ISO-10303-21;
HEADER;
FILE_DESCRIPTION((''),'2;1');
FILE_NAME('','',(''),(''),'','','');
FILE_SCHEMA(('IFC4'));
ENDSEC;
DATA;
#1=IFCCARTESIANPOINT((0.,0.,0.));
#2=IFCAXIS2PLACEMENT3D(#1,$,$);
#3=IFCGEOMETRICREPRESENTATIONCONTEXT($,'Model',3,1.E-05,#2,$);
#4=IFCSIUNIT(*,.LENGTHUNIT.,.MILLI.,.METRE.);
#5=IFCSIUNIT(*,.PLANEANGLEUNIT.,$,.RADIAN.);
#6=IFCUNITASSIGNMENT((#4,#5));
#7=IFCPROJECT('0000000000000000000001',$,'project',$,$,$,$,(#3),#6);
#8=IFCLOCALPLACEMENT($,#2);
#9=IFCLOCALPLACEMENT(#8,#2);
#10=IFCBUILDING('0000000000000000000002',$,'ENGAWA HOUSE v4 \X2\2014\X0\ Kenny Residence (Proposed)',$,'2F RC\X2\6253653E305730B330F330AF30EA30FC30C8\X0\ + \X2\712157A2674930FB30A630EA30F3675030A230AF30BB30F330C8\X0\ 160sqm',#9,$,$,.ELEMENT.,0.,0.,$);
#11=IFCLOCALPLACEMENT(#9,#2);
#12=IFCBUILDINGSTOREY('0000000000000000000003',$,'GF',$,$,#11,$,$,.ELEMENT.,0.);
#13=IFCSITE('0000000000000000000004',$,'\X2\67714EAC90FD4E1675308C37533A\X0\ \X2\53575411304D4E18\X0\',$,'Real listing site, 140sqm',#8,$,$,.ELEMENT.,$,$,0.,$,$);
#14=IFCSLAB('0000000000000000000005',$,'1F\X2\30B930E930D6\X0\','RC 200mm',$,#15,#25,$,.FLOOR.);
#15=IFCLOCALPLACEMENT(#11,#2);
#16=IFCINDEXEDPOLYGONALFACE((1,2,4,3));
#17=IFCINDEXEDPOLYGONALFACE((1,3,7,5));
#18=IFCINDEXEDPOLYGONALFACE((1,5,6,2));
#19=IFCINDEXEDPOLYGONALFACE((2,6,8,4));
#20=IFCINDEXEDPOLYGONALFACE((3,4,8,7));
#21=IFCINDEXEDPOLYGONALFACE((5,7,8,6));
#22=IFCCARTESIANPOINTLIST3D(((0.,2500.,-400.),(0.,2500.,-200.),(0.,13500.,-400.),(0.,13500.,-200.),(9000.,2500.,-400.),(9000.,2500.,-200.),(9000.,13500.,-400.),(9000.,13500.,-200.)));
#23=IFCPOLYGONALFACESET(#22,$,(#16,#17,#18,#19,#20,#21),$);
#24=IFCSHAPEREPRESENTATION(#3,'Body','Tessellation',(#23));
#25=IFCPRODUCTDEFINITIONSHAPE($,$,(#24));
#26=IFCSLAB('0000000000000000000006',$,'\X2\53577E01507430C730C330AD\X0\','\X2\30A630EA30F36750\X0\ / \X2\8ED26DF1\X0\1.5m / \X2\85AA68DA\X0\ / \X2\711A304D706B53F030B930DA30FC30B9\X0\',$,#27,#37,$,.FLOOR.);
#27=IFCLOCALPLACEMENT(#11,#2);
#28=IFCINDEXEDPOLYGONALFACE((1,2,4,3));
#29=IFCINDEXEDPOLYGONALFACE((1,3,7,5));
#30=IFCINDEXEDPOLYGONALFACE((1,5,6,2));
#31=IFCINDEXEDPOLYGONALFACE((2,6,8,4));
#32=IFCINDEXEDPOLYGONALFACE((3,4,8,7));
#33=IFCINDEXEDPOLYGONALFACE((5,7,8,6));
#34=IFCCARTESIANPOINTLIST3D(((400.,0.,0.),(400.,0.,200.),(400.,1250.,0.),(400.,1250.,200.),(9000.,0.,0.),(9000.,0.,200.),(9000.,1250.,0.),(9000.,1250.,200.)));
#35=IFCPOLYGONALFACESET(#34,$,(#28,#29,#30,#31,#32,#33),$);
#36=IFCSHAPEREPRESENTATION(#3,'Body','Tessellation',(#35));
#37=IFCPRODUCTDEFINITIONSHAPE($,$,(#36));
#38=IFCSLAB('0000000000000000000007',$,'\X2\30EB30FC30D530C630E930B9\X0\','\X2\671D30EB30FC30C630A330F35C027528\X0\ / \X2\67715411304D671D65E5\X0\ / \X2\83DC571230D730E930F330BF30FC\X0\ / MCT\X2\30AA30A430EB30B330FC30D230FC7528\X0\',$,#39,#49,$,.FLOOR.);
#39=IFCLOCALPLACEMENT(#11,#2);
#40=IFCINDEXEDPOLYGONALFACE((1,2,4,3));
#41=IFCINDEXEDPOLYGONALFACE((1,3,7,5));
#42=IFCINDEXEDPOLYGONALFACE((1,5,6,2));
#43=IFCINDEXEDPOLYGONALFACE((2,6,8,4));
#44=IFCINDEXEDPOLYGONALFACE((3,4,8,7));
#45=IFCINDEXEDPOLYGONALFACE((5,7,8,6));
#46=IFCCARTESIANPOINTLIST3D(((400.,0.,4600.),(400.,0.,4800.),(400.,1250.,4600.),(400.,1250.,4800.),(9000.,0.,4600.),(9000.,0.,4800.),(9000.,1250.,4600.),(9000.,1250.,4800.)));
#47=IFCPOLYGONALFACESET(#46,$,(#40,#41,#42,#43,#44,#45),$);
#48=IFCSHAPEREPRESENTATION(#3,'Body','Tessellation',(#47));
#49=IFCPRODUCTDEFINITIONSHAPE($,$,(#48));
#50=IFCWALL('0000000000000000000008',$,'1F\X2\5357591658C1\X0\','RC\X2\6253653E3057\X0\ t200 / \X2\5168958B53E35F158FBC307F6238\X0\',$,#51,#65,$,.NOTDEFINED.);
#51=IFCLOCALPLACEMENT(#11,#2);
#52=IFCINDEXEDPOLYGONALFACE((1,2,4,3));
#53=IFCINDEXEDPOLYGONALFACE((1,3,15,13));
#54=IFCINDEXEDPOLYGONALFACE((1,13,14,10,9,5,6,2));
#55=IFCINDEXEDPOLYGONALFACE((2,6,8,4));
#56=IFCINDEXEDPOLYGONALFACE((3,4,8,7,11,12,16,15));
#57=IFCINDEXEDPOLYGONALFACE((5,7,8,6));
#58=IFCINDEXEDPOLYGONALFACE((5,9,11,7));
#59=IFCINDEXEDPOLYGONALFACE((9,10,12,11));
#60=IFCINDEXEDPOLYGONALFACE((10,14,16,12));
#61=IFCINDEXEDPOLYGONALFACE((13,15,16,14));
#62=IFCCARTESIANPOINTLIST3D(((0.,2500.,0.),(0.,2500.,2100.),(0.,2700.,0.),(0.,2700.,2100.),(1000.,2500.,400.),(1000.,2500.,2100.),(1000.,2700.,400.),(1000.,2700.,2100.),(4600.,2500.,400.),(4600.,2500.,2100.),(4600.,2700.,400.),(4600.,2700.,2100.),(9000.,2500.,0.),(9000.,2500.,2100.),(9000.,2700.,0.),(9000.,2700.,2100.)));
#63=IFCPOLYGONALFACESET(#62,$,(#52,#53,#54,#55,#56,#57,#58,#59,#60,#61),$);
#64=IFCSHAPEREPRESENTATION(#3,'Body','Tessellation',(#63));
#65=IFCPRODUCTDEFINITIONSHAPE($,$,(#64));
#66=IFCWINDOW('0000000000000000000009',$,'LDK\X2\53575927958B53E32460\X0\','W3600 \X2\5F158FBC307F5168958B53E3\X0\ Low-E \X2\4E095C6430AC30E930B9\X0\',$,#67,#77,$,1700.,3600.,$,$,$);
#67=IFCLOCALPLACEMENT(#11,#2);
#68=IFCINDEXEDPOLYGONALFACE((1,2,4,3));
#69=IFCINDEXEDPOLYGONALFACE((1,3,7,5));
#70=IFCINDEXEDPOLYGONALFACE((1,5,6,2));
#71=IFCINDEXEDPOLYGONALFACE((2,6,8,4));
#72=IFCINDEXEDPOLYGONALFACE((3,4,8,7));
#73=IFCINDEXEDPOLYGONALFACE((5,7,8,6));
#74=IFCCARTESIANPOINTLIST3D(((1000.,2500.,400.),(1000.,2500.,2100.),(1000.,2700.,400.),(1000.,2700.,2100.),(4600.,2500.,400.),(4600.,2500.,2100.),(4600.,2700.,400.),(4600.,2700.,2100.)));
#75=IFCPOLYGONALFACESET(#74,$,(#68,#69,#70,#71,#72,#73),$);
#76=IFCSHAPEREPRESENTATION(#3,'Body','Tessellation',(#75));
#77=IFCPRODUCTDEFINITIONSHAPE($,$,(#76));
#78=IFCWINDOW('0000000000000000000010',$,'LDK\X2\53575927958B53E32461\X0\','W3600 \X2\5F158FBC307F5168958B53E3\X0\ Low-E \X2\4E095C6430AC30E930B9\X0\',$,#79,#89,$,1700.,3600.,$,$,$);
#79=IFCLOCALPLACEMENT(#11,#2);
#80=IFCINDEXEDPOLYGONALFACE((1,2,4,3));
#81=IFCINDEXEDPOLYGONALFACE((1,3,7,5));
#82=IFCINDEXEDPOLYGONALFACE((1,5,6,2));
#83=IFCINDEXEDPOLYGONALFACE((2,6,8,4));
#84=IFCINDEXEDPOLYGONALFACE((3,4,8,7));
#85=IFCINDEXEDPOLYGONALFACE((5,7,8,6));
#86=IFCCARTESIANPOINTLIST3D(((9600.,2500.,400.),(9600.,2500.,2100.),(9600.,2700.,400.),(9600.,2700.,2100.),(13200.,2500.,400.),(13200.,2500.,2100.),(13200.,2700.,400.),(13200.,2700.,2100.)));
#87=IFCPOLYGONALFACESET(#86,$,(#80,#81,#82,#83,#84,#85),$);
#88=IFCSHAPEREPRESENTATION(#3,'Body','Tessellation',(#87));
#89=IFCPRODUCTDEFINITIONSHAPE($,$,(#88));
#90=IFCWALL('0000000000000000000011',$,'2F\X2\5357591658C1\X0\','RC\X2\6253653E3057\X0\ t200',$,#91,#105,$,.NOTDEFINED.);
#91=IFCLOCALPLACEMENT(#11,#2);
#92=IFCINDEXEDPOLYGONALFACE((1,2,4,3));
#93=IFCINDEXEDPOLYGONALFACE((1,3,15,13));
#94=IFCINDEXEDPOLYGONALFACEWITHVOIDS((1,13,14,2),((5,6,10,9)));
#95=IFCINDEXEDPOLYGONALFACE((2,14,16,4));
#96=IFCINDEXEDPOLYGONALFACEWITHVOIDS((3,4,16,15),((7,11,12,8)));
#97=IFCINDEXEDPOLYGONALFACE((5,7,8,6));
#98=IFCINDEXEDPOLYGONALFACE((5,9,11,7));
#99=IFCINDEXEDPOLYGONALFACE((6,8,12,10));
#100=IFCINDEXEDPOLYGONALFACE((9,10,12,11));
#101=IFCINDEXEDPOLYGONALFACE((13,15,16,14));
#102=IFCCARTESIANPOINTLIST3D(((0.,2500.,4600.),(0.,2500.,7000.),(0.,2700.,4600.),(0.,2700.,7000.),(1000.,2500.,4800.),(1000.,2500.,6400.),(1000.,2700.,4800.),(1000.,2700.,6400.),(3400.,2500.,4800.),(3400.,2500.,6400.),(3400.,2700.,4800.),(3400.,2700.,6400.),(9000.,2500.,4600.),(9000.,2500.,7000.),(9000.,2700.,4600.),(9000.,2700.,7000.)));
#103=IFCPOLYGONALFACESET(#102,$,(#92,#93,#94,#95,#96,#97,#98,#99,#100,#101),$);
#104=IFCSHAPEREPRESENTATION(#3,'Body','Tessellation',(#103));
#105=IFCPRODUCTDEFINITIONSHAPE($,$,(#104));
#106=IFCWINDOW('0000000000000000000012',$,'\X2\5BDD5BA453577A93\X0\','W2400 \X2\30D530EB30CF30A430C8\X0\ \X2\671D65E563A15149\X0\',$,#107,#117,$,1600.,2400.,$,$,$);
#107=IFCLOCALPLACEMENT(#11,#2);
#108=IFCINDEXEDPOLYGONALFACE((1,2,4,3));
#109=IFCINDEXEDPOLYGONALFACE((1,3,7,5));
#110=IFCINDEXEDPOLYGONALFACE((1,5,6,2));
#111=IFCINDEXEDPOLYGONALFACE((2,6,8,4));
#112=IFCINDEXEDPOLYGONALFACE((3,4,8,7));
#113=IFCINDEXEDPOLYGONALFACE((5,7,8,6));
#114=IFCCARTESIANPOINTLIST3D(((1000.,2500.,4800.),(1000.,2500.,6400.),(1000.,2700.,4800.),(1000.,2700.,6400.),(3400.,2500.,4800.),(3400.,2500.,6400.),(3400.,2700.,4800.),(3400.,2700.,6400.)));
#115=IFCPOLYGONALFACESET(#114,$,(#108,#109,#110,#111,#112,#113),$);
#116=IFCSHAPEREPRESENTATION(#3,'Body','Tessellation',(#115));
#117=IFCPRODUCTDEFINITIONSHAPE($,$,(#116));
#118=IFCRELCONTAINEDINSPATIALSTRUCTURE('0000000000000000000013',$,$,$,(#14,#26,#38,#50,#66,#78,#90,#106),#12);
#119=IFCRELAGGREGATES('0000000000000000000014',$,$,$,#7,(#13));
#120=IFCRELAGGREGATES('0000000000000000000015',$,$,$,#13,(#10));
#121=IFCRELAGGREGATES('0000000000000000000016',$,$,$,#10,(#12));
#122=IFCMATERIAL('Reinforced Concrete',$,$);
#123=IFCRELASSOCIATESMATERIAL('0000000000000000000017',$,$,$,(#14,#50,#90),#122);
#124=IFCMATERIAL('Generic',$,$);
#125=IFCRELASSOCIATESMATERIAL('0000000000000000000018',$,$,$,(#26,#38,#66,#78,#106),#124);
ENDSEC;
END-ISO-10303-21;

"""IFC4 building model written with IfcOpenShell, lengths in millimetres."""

from ifc_helpers import new_model, si_unit, frame, frame_2d, origin, place, context, project, spatial, rectangle, extrude, material, element, fill, save


model = new_model("IFC4")

# Units and contexts
model_context = context("Model", 3, precision=1e-05, world=origin())
ifc_project = project(units=[si_unit("LENGTHUNIT", "METRE", prefix="MILLI"), si_unit("PLANEANGLEUNIT", "RADIAN")], contexts=[model_context])

# Site, building, storey
site_placement = place(None, origin())
site = spatial("IfcSite", under=ifc_project, at=site_placement, Name="東京都世田谷区 南向き丘", ObjectType="Real listing site, 140sqm", CompositionType="ELEMENT", RefElevation=0.0)
building_placement = place(site_placement, origin())
building = spatial("IfcBuilding", under=site, at=building_placement, Name="ENGAWA HOUSE v4 — Kenny Residence (Proposed)", ObjectType="2F RC打放しコンクリート + 無垢杉・ウリン材アクセント 160sqm", CompositionType="ELEMENT", ElevationOfRefHeight=0.0, ElevationOfTerrain=0.0)
storey_placement = place(building_placement, origin())
storey = spatial("IfcBuildingStorey", under=building, at=storey_placement, Name="GF", CompositionType="ELEMENT", Elevation=0.0)

# Slabs
ifc_material_1 = material(Name="Reinforced Concrete")
slab_1_placement = place(storey_placement, frame((0.0, 1250.0, -200.0)))
element("IfcSlab", 1, at=slab_1_placement, inside=storey, material=ifc_material_1, Name="1Fスラブ", Description="RC 200mm", PredefinedType="FLOOR", context=model_context, shape_type="SweptSolid", body=[
    extrude(rectangle(XDim=9000.0, YDim=11000.0, at=frame_2d((4500.0, 5500.0))), frame((0.0, 1250.0, -200.0)), (0.0, 0.0, 1.0), 200.0),
])
ifc_material_2 = material(Name="Generic")
slab_2_placement = place(storey_placement, frame((200.0, 0.0, 0.0)))
element("IfcSlab", 2, at=slab_2_placement, inside=storey, material=ifc_material_2, Name="南縁側デッキ", Description="ウリン材 / 軒深1.5m / 薪棚 / 焚き火台スペース", PredefinedType="FLOOR", context=model_context, shape_type="SweptSolid", body=[
    extrude(rectangle(XDim=8600.0, YDim=1250.0, at=frame_2d((4300.0, 625.0))), frame((200.0, 0.0, 0.0)), (0.0, 0.0, 1.0), 200.0),
])
slab_3_placement = place(storey_placement, frame((200.0, 0.0, 2300.0)))
element("IfcSlab", 3, at=slab_3_placement, inside=storey, material=ifc_material_2, Name="ルーフテラス", Description="朝ルーティン専用 / 東向き朝日 / 菜園プランター / MCTオイルコーヒー用", PredefinedType="FLOOR", context=model_context, shape_type="SweptSolid", body=[
    extrude(rectangle(XDim=8600.0, YDim=1250.0, at=frame_2d((4300.0, 625.0))), frame((200.0, 0.0, 2300.0)), (0.0, 0.0, 1.0), 200.0),
])

# Wall, openings, windows
wall_1_placement = place(storey_placement, frame((0.0, 1250.0, 0.0)))
wall_1 = element("IfcWall", 4, at=wall_1_placement, inside=storey, material=ifc_material_1, Name="1F南外壁", Description="RC打放し t200 / 全開口引込み戸", PredefinedType="NOTDEFINED", context=model_context, shape_type="SweptSolid", body=[
    extrude(rectangle(XDim=9000.0, YDim=200.0, at=frame_2d((4500.0, 100.0))), frame((0.0, 1250.0, 0.0)), (0.0, 0.0, 1.0), 2100.0),
])
opening_1_placement = place(storey_placement, frame((500.0, 1250.0, 200.0)))
opening_1 = element("IfcOpeningElement", 5, at=opening_1_placement, cuts=wall_1, PredefinedType="NOTDEFINED", context=model_context, shape_type="SweptSolid", body=[
    extrude(rectangle(XDim=3600.0, YDim=200.0, at=frame_2d((1800.0, 100.0))), frame((500.0, 1250.0, 200.0)), (0.0, 0.0, 1.0), 1700.0),
])
opening_2_placement = place(storey_placement, frame((4800.0, 1250.0, 200.0)))
opening_2 = element("IfcOpeningElement", 6, at=opening_2_placement, cuts=wall_1, PredefinedType="NOTDEFINED", context=model_context, shape_type="SweptSolid", body=[
    extrude(rectangle(XDim=3600.0, YDim=200.0, at=frame_2d((1800.0, 100.0))), frame((4800.0, 1250.0, 200.0)), (0.0, 0.0, 1.0), 1700.0),
])
window_1_placement = place(storey_placement, frame((500.0, 1250.0, 200.0)))
window_1 = element("IfcWindow", 7, at=window_1_placement, inside=storey, material=ifc_material_2, Name="LDK南大開口①", Description="W3600 引込み全開口 Low-E 三層ガラス", OverallHeight=1700.0, OverallWidth=3600.0, context=model_context, shape_type="SweptSolid", body=[
    extrude(rectangle(XDim=3600.0, YDim=200.0, at=frame_2d((1800.0, 100.0))), frame((500.0, 1250.0, 200.0)), (0.0, 0.0, 1.0), 1700.0),
])
fill(opening_1, window_1)
window_2_placement = place(storey_placement, frame((4800.0, 1250.0, 200.0)))
window_2 = element("IfcWindow", 8, at=window_2_placement, inside=storey, material=ifc_material_2, Name="LDK南大開口②", Description="W3600 引込み全開口 Low-E 三層ガラス", OverallHeight=1700.0, OverallWidth=3600.0, context=model_context, shape_type="SweptSolid", body=[
    extrude(rectangle(XDim=3600.0, YDim=200.0, at=frame_2d((1800.0, 100.0))), frame((4800.0, 1250.0, 200.0)), (0.0, 0.0, 1.0), 1700.0),
])
fill(opening_2, window_2)

# Wall, opening, window
wall_2_placement = place(storey_placement, frame((0.0, 1250.0, 2300.0)))
wall_2 = element("IfcWall", 9, at=wall_2_placement, inside=storey, material=ifc_material_1, Name="2F南外壁", Description="RC打放し t200", PredefinedType="NOTDEFINED", context=model_context, shape_type="SweptSolid", body=[
    extrude(rectangle(XDim=9000.0, YDim=200.0, at=frame_2d((4500.0, 100.0))), frame((0.0, 1250.0, 2300.0)), (0.0, 0.0, 1.0), 2400.0),
])
opening_3_placement = place(storey_placement, frame((500.0, 1250.0, 2400.0)))
opening_3 = element("IfcOpeningElement", 10, at=opening_3_placement, cuts=wall_2, PredefinedType="NOTDEFINED", context=model_context, shape_type="SweptSolid", body=[
    extrude(rectangle(XDim=2400.0, YDim=200.0, at=frame_2d((1200.0, 100.0))), frame((500.0, 1250.0, 2400.0)), (0.0, 0.0, 1.0), 1600.0),
])
window_3_placement = place(storey_placement, frame((500.0, 1250.0, 2400.0)))
window_3 = element("IfcWindow", 11, at=window_3_placement, inside=storey, material=ifc_material_2, Name="寝室南窓", Description="W2400 フルハイト 朝日採光", OverallHeight=1600.0, OverallWidth=2400.0, context=model_context, shape_type="SweptSolid", body=[
    extrude(rectangle(XDim=2400.0, YDim=200.0, at=frame_2d((1200.0, 100.0))), frame((500.0, 1250.0, 2400.0)), (0.0, 0.0, 1.0), 1600.0),
])
fill(opening_3, window_3)

save(model, "model.ifc")
